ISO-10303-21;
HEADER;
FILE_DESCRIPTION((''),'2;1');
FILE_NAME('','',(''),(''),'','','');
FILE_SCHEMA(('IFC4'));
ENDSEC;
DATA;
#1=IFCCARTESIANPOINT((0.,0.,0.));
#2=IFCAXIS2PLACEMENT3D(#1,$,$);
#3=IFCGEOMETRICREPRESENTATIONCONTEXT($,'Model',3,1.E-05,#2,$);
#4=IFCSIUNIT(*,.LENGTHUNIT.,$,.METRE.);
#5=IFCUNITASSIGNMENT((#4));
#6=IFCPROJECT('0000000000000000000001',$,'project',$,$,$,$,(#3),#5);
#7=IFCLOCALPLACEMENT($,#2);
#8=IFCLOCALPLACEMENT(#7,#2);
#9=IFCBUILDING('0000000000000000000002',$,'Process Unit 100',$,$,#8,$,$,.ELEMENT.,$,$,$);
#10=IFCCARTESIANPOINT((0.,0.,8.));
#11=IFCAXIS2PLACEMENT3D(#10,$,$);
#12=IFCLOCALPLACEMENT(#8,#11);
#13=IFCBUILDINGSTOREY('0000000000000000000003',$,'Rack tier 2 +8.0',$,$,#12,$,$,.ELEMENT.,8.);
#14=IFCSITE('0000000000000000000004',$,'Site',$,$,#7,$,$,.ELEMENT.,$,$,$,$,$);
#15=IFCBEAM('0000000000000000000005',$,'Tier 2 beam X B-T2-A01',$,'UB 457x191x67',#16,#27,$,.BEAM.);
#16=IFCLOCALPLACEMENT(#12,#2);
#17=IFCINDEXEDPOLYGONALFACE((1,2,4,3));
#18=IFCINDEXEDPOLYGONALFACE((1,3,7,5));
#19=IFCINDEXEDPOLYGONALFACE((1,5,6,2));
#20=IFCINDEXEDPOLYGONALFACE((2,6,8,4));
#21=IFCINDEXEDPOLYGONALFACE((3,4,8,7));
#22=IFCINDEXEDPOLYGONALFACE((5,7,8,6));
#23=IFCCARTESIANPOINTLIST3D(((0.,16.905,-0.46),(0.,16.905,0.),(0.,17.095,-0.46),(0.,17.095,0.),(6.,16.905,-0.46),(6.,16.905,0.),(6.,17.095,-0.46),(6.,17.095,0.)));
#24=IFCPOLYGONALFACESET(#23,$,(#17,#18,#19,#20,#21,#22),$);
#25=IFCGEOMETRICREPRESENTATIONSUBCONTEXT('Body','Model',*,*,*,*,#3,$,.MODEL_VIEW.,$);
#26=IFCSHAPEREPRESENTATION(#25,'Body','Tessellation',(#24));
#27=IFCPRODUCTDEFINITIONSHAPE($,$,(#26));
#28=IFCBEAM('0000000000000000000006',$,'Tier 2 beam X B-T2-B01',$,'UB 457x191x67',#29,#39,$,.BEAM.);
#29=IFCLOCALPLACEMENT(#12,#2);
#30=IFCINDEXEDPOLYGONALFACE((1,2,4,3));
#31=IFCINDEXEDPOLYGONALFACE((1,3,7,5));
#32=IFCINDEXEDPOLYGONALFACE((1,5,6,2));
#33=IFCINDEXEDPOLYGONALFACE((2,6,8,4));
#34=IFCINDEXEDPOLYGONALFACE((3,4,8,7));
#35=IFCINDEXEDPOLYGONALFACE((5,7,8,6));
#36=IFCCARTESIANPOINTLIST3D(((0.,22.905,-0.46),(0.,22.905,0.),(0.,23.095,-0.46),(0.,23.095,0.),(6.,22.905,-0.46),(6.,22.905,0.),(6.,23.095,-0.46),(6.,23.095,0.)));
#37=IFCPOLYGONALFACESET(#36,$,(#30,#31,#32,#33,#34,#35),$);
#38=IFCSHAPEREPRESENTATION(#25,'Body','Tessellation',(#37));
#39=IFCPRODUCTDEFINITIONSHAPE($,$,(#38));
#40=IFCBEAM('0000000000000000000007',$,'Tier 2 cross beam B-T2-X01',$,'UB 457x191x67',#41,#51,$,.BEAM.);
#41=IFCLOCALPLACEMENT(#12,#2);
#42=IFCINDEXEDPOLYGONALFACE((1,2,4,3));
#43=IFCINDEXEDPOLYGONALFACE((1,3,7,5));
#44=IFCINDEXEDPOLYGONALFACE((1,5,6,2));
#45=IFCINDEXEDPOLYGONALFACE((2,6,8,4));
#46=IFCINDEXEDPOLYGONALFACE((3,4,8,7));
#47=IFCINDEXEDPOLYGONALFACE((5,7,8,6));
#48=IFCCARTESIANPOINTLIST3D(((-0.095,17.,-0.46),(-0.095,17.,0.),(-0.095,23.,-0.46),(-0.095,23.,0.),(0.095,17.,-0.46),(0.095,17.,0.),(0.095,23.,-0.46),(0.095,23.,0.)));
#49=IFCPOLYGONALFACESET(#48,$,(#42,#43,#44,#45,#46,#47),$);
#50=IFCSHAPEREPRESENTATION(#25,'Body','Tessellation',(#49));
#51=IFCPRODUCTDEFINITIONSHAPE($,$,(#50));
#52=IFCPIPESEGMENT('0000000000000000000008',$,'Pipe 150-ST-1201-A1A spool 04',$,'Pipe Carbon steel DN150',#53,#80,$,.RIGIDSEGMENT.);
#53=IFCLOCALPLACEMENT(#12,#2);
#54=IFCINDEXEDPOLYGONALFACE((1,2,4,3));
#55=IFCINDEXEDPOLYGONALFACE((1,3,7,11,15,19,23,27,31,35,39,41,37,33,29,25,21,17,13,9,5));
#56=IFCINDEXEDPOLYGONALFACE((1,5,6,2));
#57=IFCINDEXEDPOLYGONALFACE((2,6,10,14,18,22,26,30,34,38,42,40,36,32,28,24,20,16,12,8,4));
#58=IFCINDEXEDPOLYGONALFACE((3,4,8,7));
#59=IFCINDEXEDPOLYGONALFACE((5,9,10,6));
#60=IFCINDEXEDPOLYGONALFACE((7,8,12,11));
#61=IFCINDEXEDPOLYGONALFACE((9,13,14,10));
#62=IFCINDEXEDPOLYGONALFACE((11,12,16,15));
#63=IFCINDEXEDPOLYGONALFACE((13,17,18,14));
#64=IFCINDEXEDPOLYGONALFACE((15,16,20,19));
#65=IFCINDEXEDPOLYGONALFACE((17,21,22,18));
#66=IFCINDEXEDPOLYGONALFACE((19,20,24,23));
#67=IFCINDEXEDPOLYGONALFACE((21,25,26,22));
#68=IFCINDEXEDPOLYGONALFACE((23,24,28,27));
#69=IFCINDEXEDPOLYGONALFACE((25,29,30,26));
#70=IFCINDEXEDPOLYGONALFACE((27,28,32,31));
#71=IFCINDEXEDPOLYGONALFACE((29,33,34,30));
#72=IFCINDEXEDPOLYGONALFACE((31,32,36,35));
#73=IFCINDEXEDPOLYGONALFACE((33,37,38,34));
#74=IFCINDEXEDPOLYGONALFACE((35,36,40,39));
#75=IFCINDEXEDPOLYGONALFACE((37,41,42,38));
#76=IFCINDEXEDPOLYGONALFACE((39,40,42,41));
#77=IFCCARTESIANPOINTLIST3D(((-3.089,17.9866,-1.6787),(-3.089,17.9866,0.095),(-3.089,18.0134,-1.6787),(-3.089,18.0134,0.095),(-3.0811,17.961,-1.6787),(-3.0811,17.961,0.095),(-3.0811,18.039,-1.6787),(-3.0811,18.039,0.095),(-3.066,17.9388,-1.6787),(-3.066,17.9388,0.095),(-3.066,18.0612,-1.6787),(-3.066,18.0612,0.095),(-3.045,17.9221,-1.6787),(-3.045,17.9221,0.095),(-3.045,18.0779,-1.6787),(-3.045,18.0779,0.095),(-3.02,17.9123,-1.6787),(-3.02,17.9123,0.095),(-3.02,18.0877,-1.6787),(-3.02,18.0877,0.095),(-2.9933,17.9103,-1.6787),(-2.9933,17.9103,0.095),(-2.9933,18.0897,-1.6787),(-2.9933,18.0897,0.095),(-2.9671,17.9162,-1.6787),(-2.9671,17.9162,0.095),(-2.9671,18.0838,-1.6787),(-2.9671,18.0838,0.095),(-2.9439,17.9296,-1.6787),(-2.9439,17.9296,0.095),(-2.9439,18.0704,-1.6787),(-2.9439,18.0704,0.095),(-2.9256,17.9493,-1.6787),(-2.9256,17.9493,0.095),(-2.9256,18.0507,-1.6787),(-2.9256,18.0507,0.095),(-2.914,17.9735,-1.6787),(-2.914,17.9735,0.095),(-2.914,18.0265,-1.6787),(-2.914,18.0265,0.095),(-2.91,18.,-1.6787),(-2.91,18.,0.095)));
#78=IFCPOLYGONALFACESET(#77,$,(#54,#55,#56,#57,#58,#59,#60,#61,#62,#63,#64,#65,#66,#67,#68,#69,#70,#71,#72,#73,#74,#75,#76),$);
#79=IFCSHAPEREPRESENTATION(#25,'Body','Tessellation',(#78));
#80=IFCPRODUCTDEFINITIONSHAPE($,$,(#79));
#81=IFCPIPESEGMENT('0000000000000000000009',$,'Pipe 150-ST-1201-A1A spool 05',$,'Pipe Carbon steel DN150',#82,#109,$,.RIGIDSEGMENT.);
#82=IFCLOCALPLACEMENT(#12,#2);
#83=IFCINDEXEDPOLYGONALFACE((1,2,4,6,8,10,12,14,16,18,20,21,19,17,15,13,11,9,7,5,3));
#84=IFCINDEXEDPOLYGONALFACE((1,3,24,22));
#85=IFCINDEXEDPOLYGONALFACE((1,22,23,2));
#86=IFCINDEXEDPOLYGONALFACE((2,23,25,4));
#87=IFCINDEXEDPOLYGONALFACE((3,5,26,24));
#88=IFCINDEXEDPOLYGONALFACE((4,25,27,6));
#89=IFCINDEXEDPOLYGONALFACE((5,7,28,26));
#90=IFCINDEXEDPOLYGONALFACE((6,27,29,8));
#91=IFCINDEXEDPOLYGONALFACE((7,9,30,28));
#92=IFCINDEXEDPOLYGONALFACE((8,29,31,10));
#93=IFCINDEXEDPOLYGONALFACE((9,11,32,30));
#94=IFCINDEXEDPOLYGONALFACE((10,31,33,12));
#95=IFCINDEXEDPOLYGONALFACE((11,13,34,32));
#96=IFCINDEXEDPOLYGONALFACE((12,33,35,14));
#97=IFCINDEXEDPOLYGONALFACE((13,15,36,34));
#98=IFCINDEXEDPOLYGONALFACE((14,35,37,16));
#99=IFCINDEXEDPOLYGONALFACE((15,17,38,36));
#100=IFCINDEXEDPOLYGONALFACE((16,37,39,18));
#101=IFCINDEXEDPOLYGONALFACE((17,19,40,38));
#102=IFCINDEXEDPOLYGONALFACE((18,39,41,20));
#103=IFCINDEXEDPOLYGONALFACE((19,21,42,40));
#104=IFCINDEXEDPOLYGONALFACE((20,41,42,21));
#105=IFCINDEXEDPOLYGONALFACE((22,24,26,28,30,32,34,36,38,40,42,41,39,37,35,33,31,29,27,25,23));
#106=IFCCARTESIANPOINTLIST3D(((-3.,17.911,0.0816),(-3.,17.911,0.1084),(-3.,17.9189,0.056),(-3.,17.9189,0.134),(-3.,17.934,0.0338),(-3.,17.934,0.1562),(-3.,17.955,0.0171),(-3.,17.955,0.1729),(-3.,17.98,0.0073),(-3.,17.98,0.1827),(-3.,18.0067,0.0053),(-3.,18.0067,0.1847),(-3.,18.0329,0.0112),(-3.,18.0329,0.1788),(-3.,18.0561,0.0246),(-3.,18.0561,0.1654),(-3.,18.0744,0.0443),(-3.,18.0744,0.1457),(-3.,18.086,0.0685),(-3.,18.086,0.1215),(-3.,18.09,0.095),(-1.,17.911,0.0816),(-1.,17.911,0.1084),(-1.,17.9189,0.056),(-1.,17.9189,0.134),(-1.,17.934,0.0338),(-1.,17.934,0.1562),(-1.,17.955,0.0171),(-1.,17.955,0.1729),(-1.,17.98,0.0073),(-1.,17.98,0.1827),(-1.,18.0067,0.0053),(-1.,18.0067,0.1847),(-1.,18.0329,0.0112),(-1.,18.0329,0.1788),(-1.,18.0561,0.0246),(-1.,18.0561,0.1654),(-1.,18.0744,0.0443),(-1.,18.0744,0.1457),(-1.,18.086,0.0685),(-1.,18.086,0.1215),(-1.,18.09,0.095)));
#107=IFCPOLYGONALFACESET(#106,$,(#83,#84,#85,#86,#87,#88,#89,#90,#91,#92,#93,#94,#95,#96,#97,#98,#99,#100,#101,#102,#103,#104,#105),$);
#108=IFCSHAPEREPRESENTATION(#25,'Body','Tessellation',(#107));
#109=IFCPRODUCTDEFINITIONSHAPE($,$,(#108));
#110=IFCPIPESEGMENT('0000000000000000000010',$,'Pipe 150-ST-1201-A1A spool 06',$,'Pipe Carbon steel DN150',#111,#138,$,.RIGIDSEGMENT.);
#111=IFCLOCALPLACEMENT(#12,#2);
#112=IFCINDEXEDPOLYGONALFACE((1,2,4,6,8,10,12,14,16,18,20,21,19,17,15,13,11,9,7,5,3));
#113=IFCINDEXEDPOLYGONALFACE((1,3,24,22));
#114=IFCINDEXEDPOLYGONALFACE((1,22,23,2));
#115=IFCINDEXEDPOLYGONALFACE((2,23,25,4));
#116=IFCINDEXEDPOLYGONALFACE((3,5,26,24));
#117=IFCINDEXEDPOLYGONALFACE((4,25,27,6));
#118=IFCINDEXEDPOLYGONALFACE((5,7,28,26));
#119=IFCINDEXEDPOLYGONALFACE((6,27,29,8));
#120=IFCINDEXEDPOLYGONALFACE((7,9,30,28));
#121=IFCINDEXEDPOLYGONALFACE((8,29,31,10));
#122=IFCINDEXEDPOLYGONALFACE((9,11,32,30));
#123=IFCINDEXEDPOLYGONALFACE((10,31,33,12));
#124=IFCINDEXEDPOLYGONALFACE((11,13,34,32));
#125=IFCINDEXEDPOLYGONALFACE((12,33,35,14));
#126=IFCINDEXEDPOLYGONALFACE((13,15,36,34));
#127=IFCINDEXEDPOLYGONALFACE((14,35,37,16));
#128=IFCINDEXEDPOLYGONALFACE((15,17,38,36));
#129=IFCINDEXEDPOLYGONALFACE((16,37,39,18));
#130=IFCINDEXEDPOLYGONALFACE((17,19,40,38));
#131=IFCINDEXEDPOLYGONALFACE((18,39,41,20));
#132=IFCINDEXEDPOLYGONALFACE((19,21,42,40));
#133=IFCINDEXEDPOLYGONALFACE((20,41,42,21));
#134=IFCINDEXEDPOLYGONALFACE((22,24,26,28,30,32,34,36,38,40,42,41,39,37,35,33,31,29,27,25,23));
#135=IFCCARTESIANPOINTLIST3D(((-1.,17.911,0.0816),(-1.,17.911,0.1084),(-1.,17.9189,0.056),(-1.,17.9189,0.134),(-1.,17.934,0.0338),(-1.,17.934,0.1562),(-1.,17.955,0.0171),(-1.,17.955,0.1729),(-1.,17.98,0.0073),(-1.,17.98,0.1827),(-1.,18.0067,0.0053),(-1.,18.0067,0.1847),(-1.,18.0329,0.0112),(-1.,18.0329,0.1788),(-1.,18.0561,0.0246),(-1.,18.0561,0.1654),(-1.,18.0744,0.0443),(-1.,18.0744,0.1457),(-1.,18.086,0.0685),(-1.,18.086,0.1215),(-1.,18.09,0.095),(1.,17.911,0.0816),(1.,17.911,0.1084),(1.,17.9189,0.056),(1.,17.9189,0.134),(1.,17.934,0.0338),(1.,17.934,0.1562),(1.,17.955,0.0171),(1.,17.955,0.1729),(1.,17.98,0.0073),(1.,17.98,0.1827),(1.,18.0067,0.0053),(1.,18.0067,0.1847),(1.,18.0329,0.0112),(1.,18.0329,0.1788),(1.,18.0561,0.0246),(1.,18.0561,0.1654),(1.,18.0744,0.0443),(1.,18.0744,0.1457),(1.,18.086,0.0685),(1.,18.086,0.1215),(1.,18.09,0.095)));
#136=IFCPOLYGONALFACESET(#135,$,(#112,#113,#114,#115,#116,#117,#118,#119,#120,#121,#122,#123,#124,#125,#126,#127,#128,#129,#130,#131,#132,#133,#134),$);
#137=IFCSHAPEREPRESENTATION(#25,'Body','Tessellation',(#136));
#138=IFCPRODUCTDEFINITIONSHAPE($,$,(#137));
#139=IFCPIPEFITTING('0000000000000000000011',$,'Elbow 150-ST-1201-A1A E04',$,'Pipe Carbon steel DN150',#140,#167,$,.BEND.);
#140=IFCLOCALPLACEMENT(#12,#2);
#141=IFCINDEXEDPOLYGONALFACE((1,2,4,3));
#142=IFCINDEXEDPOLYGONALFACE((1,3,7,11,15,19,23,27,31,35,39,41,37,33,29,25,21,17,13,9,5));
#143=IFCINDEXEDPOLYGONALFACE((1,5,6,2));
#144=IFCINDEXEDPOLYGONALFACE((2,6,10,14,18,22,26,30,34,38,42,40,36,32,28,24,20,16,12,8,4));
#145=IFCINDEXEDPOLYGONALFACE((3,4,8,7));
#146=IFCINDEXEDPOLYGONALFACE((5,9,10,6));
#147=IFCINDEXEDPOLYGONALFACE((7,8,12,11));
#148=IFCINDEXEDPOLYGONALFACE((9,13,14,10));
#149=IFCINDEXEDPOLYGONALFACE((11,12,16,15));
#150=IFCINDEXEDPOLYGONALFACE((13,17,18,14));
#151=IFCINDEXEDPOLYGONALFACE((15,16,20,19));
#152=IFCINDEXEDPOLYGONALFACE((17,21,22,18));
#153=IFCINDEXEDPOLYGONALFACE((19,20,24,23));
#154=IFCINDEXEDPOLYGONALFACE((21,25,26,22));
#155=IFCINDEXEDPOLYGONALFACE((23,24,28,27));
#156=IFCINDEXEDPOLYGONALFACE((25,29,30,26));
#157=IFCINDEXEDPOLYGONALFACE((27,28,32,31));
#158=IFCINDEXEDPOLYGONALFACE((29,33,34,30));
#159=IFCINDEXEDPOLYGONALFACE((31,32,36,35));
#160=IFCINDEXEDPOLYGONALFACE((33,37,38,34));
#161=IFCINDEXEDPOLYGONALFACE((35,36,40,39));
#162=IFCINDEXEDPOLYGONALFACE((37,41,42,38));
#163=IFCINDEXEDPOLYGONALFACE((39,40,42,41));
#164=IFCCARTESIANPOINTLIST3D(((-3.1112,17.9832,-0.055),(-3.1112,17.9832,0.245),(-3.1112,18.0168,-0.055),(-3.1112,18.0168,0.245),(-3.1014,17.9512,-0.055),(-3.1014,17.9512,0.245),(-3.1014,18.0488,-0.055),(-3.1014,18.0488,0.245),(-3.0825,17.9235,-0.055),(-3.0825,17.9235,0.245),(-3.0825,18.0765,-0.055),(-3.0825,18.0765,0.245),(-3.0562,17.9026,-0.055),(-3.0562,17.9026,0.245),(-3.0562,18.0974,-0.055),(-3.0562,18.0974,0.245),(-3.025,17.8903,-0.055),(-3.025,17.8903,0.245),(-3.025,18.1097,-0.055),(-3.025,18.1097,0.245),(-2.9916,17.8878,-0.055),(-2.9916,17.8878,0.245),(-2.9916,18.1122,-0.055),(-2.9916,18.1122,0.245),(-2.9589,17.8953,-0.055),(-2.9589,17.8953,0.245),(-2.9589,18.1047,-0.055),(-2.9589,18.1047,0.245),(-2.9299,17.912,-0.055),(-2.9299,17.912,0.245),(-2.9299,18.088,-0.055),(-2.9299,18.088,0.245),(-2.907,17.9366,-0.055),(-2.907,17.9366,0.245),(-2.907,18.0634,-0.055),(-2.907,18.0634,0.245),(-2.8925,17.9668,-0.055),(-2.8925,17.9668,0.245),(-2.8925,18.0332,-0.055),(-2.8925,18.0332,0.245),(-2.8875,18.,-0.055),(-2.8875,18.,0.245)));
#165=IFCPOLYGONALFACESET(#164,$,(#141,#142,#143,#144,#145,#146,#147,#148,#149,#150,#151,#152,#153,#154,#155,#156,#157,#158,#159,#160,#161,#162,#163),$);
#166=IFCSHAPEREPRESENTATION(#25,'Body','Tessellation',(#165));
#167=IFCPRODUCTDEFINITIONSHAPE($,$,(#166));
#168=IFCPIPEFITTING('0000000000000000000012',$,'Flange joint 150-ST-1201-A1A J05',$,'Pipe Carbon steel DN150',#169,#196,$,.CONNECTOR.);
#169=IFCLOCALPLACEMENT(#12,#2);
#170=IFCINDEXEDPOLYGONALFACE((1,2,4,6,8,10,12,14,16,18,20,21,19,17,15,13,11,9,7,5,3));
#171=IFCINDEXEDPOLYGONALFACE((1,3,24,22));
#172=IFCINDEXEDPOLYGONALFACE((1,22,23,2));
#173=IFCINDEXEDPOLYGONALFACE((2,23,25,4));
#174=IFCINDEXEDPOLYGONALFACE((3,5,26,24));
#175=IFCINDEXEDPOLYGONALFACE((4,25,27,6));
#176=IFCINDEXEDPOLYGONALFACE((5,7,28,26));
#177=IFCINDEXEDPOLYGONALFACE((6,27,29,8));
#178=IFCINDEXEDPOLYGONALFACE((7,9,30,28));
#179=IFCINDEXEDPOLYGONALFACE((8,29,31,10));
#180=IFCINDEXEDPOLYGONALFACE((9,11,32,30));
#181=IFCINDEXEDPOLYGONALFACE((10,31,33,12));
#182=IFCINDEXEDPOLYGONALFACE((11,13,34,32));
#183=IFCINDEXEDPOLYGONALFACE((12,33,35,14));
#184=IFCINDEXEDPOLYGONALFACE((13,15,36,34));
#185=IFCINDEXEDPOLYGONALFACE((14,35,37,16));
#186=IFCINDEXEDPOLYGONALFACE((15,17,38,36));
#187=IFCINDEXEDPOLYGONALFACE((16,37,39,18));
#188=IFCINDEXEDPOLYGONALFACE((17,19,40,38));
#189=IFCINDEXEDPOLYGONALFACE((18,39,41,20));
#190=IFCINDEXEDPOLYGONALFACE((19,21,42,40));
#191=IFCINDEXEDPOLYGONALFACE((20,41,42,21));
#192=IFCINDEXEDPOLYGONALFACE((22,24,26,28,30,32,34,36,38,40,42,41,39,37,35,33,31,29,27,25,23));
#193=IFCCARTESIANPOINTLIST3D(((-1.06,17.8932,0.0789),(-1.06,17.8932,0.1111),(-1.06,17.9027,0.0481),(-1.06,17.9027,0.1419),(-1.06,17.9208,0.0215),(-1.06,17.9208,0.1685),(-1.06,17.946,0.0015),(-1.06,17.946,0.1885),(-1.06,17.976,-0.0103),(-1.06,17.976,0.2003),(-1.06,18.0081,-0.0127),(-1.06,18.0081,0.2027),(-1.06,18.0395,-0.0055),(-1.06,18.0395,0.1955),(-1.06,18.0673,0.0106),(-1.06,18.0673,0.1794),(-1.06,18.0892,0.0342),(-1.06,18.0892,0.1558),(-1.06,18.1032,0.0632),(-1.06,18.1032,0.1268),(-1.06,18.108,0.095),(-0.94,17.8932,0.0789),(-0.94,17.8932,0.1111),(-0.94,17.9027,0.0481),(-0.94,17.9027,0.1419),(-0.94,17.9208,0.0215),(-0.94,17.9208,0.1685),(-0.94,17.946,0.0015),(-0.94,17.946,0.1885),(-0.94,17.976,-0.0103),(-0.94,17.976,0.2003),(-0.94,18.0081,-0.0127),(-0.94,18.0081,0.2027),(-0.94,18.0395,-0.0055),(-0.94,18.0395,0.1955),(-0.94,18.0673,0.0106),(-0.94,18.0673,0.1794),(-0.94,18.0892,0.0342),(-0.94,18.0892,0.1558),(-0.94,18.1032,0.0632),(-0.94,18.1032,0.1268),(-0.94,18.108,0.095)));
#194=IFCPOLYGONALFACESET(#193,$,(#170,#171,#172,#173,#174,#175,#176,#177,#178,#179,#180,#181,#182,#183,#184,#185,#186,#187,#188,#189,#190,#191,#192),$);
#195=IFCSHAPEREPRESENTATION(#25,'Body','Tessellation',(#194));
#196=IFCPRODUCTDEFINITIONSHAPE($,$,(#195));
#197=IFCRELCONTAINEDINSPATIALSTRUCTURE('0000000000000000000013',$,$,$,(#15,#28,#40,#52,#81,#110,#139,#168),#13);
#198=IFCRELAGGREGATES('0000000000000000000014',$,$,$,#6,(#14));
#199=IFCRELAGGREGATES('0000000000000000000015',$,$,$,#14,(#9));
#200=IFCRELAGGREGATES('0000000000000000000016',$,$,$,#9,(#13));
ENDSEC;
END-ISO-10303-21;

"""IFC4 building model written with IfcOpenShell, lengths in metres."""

from ifc_helpers import new_model, si_unit, frame, origin, place, context, subcontext, project, spatial, rectangle, circle, extrude, element, save


model = new_model("IFC4")

# Units and contexts
model_context = context("Model", 3, precision=1e-05, world=origin())
body_context = subcontext(model_context, "Body", "Model", "MODEL_VIEW")
ifc_project = project(units=[si_unit("LENGTHUNIT", "METRE")], contexts=[model_context])

# Site, building, storey
site_placement = place(None, origin())
site = spatial("IfcSite", under=ifc_project, at=site_placement, Name="Site", CompositionType="ELEMENT")
building_placement = place(site_placement, origin())
building = spatial("IfcBuilding", under=site, at=building_placement, Name="Process Unit 100", CompositionType="ELEMENT")
storey_placement = place(building_placement, frame((0.0, 0.0, 8.0)))
storey = spatial("IfcBuildingStorey", under=building, at=storey_placement, Name="Rack tier 2 +8.0", CompositionType="ELEMENT", Elevation=8.0)

# Beams
for number, where, z_axis, x_axis, name in (
    (1, (0.0, 17.0, -0.23), (1.0, 0.0, 0.0), (0.0, 1.0, 0.0), "Tier 2 beam X B-T2-A01"),
    (2, (0.0, 23.0, -0.23), (1.0, 0.0, 0.0), (0.0, 1.0, 0.0), "Tier 2 beam X B-T2-B01"),
    (3, (0.0, 17.0, -0.23), (0.0, 1.0, 0.0), (-1.0, 0.0, 0.0), "Tier 2 cross beam B-T2-X01"),
):
    element("IfcBeam", number, at=place(storey_placement, frame(where, z_axis=z_axis, x_axis=x_axis)), inside=storey, Name=name, ObjectType="UB 457x191x67", PredefinedType="BEAM", context=body_context, shape_type="SweptSolid", body=[
        extrude(rectangle(XDim=0.19, YDim=0.46), origin(), (0.0, 0.0, 1.0), 6.0),
    ])

# Pipe segments
pipe_segment_1_placement = place(storey_placement, frame((-3.0, 18.0, -1.6787), z_axis=(0.0, 0.0, 1.0), x_axis=(1.0, 0.0, 0.0)))
element("IfcPipeSegment", 4, at=pipe_segment_1_placement, inside=storey, Name="Pipe 150-ST-1201-A1A spool 04", ObjectType="Pipe Carbon steel DN150", PredefinedType="RIGIDSEGMENT", context=body_context, shape_type="SweptSolid", body=[
    extrude(circle(Radius=0.09), origin(), (0.0, 0.0, 1.0), 1.7738),
])
for number, where, z_axis, x_axis, name in (
    (5, (-3.0, 18.0, 0.095), (1.0, 0.0, 0.0), (0.0, 1.0, 0.0), "Pipe 150-ST-1201-A1A spool 05"),
    (6, (-1.0, 18.0, 0.095), (1.0, 0.0, 0.0), (0.0, 1.0, 0.0), "Pipe 150-ST-1201-A1A spool 06"),
):
    element("IfcPipeSegment", number, at=place(storey_placement, frame(where, z_axis=z_axis, x_axis=x_axis)), inside=storey, Name=name, ObjectType="Pipe Carbon steel DN150", PredefinedType="RIGIDSEGMENT", context=body_context, shape_type="SweptSolid", body=[
        extrude(circle(Radius=0.09), origin(), (0.0, 0.0, 1.0), 2.0),
    ])

# Pipe fittings
pipe_fitting_1_placement = place(storey_placement, frame((-3.0, 18.0, -0.055), z_axis=(0.0, 0.0, 1.0), x_axis=(1.0, 0.0, 0.0)))
element("IfcPipeFitting", 7, at=pipe_fitting_1_placement, inside=storey, Name="Elbow 150-ST-1201-A1A E04", ObjectType="Pipe Carbon steel DN150", PredefinedType="BEND", context=body_context, shape_type="SweptSolid", body=[
    extrude(circle(Radius=0.1125), origin(), (0.0, 0.0, 1.0), 0.3),
])
for number, where, z_axis, x_axis, name in (
    (8, (-1.06, 18.0, 0.095), (1.0, 0.0, 0.0), (0.0, 1.0, 0.0), "Flange joint 150-ST-1201-A1A J05"),
):
    element("IfcPipeFitting", number, at=place(storey_placement, frame(where, z_axis=z_axis, x_axis=x_axis)), inside=storey, Name=name, ObjectType="Pipe Carbon steel DN150", PredefinedType="CONNECTOR", context=body_context, shape_type="SweptSolid", body=[
        extrude(circle(Radius=0.108), origin(), (0.0, 0.0, 1.0), 0.12),
    ])

save(model, "model.ifc")
